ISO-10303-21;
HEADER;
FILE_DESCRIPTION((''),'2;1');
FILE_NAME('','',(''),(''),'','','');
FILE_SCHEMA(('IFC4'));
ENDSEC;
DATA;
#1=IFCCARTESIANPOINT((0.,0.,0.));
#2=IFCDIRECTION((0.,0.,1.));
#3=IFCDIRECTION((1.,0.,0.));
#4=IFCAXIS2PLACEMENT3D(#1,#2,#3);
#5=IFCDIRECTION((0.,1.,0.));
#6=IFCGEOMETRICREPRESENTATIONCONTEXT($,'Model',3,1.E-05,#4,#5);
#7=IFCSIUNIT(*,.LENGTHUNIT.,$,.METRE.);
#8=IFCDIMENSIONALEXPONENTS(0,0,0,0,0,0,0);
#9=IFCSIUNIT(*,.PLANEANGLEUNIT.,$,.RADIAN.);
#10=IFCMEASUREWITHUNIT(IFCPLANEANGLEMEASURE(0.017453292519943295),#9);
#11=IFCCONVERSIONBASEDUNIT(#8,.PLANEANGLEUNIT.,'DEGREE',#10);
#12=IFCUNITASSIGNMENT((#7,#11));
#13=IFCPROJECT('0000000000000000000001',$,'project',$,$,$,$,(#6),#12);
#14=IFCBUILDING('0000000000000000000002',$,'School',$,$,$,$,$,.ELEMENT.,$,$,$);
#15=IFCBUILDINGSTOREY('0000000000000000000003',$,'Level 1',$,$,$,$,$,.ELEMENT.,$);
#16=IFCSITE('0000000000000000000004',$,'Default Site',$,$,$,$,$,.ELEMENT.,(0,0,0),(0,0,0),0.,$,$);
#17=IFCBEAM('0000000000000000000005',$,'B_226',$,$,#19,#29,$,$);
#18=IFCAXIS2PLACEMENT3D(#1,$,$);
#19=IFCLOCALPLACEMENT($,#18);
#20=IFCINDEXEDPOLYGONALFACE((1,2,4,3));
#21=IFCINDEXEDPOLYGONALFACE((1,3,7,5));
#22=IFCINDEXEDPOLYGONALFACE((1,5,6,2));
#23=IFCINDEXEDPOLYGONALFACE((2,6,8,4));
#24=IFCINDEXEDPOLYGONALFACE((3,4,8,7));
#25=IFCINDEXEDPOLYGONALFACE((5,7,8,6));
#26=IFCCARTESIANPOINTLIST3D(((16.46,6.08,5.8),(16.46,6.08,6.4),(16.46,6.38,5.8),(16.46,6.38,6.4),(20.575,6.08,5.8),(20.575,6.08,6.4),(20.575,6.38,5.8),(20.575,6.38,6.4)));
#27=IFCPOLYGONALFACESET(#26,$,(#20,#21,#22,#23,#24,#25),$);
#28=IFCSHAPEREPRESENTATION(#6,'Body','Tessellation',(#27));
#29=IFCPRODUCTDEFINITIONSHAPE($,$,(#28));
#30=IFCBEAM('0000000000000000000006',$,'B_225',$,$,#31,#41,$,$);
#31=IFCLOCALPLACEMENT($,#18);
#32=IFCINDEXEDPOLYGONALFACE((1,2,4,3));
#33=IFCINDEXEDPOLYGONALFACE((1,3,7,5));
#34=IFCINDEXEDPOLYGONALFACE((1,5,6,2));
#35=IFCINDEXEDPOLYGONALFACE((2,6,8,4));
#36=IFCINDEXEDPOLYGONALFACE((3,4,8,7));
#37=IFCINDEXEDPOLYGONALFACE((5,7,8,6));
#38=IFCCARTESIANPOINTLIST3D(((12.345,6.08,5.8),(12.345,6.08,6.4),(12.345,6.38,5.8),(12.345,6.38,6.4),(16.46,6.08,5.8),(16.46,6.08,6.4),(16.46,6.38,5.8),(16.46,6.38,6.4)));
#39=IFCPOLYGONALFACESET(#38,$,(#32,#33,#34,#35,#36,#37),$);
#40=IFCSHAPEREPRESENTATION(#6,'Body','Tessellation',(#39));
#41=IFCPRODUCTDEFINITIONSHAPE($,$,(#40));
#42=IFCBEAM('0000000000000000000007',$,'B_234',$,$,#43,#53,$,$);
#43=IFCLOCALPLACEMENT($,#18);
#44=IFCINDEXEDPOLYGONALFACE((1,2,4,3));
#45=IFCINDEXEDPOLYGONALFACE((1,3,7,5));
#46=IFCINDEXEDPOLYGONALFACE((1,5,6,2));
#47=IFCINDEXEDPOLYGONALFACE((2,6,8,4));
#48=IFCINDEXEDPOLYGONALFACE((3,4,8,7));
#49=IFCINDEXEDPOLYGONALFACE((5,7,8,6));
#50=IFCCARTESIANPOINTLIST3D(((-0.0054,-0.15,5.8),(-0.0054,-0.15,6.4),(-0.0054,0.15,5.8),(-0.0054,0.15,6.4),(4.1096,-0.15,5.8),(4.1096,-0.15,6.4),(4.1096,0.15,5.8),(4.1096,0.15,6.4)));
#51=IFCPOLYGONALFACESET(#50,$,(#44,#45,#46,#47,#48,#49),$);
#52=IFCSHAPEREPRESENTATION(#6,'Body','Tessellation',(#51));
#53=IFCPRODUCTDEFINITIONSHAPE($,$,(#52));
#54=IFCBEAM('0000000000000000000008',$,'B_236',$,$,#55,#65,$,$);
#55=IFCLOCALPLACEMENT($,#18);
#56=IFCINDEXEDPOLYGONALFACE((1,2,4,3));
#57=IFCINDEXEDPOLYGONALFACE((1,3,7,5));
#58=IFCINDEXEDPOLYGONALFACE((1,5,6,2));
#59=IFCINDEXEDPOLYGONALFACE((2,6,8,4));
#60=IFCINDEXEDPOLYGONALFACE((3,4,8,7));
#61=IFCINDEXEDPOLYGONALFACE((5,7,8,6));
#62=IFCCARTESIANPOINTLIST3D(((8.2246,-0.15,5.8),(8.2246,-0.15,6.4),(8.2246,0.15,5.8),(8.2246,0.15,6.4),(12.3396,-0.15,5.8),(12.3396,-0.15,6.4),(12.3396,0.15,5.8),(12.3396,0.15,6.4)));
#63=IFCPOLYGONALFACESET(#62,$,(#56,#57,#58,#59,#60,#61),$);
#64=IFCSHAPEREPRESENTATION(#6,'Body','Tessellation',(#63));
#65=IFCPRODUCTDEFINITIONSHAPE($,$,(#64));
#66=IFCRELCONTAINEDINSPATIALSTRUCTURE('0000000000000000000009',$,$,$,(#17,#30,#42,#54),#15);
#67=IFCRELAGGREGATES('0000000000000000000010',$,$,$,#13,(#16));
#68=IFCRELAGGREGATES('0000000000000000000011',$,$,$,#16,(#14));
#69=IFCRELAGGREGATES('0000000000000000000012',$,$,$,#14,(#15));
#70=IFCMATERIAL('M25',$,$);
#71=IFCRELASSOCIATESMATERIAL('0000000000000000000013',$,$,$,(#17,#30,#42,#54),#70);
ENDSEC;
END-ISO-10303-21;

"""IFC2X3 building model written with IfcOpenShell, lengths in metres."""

from ifc_helpers import new_model, entity, si_unit, converted_unit, direction, frame, frame_2d, origin_with_axes, place, context, project, spatial, rectangle, extrude, material, element, save


model = new_model("IFC2X3")

# Units and contexts
model_context = context("Model", 3, precision=1e-05, world=origin_with_axes(), true_north=direction((0.0, 1.0, 0.0)))
ifc_project = project(units=[si_unit("LENGTHUNIT", "METRE"), converted_unit("PLANEANGLEUNIT", "DEGREE", entity("IfcPlaneAngleMeasure", 0.017453292519943295), si_unit("PLANEANGLEUNIT", "RADIAN"), dimensions=[0, 0, 0, 0, 0, 0, 0])], contexts=[model_context])

# Site, building, storey
site = spatial("IfcSite", under=ifc_project, Name="Default Site", CompositionType="ELEMENT", RefLatitude=(0, 0, 0), RefLongitude=(0, 0, 0), RefElevation=0.0)
building = spatial("IfcBuilding", under=site, Name="School", CompositionType="ELEMENT")
storey = spatial("IfcBuildingStorey", under=building, Name="Level 1", CompositionType="ELEMENT")

# Beams
ifc_material = material(Name="M25")
placement = place(None, origin_with_axes())
element("IfcBeam", 1, at=placement, inside=storey, material=ifc_material, Name="B_226", context=model_context, shape_type="SweptSolid", body=[
    extrude(rectangle(XDim=0.3, YDim=0.6, at=frame_2d((0.0, 0.0), x_axis=(0.0, 1.0, 0.0))), frame((16.46, 6.23, 6.1), z_axis=(1.0, 0.0, 0.0), x_axis=(0.0, 0.0, -1.0)), (0.0, 0.0, 1.0), 4.115),
])
element("IfcBeam", 2, at=placement, inside=storey, material=ifc_material, Name="B_225", context=model_context, shape_type="SweptSolid", body=[
    extrude(rectangle(XDim=0.3, YDim=0.6, at=frame_2d((0.0, 0.0), x_axis=(0.0, 1.0, 0.0))), frame((12.345, 6.23, 6.1), z_axis=(1.0, 0.0, 0.0), x_axis=(0.0, 0.0, -1.0)), (0.0, 0.0, 1.0), 4.115),
])
element("IfcBeam", 3, at=placement, inside=storey, material=ifc_material, Name="B_234", context=model_context, shape_type="SweptSolid", body=[
    extrude(rectangle(XDim=0.3, YDim=0.6, at=frame_2d((0.0, 0.0), x_axis=(0.0, 1.0, 0.0))), frame((-0.0054, 0.0, 6.1), z_axis=(1.0, 0.0, 0.0), x_axis=(0.0, 0.0, -1.0)), (0.0, 0.0, 1.0), 4.115),
])
element("IfcBeam", 4, at=placement, inside=storey, material=ifc_material, Name="B_236", context=model_context, shape_type="SweptSolid", body=[
    extrude(rectangle(XDim=0.3, YDim=0.6, at=frame_2d((0.0, 0.0), x_axis=(0.0, 1.0, 0.0))), frame((8.2246, 0.0, 6.1), z_axis=(1.0, 0.0, 0.0), x_axis=(0.0, 0.0, -1.0)), (0.0, 0.0, 1.0), 4.115),
])

save(model, "model.ifc")
